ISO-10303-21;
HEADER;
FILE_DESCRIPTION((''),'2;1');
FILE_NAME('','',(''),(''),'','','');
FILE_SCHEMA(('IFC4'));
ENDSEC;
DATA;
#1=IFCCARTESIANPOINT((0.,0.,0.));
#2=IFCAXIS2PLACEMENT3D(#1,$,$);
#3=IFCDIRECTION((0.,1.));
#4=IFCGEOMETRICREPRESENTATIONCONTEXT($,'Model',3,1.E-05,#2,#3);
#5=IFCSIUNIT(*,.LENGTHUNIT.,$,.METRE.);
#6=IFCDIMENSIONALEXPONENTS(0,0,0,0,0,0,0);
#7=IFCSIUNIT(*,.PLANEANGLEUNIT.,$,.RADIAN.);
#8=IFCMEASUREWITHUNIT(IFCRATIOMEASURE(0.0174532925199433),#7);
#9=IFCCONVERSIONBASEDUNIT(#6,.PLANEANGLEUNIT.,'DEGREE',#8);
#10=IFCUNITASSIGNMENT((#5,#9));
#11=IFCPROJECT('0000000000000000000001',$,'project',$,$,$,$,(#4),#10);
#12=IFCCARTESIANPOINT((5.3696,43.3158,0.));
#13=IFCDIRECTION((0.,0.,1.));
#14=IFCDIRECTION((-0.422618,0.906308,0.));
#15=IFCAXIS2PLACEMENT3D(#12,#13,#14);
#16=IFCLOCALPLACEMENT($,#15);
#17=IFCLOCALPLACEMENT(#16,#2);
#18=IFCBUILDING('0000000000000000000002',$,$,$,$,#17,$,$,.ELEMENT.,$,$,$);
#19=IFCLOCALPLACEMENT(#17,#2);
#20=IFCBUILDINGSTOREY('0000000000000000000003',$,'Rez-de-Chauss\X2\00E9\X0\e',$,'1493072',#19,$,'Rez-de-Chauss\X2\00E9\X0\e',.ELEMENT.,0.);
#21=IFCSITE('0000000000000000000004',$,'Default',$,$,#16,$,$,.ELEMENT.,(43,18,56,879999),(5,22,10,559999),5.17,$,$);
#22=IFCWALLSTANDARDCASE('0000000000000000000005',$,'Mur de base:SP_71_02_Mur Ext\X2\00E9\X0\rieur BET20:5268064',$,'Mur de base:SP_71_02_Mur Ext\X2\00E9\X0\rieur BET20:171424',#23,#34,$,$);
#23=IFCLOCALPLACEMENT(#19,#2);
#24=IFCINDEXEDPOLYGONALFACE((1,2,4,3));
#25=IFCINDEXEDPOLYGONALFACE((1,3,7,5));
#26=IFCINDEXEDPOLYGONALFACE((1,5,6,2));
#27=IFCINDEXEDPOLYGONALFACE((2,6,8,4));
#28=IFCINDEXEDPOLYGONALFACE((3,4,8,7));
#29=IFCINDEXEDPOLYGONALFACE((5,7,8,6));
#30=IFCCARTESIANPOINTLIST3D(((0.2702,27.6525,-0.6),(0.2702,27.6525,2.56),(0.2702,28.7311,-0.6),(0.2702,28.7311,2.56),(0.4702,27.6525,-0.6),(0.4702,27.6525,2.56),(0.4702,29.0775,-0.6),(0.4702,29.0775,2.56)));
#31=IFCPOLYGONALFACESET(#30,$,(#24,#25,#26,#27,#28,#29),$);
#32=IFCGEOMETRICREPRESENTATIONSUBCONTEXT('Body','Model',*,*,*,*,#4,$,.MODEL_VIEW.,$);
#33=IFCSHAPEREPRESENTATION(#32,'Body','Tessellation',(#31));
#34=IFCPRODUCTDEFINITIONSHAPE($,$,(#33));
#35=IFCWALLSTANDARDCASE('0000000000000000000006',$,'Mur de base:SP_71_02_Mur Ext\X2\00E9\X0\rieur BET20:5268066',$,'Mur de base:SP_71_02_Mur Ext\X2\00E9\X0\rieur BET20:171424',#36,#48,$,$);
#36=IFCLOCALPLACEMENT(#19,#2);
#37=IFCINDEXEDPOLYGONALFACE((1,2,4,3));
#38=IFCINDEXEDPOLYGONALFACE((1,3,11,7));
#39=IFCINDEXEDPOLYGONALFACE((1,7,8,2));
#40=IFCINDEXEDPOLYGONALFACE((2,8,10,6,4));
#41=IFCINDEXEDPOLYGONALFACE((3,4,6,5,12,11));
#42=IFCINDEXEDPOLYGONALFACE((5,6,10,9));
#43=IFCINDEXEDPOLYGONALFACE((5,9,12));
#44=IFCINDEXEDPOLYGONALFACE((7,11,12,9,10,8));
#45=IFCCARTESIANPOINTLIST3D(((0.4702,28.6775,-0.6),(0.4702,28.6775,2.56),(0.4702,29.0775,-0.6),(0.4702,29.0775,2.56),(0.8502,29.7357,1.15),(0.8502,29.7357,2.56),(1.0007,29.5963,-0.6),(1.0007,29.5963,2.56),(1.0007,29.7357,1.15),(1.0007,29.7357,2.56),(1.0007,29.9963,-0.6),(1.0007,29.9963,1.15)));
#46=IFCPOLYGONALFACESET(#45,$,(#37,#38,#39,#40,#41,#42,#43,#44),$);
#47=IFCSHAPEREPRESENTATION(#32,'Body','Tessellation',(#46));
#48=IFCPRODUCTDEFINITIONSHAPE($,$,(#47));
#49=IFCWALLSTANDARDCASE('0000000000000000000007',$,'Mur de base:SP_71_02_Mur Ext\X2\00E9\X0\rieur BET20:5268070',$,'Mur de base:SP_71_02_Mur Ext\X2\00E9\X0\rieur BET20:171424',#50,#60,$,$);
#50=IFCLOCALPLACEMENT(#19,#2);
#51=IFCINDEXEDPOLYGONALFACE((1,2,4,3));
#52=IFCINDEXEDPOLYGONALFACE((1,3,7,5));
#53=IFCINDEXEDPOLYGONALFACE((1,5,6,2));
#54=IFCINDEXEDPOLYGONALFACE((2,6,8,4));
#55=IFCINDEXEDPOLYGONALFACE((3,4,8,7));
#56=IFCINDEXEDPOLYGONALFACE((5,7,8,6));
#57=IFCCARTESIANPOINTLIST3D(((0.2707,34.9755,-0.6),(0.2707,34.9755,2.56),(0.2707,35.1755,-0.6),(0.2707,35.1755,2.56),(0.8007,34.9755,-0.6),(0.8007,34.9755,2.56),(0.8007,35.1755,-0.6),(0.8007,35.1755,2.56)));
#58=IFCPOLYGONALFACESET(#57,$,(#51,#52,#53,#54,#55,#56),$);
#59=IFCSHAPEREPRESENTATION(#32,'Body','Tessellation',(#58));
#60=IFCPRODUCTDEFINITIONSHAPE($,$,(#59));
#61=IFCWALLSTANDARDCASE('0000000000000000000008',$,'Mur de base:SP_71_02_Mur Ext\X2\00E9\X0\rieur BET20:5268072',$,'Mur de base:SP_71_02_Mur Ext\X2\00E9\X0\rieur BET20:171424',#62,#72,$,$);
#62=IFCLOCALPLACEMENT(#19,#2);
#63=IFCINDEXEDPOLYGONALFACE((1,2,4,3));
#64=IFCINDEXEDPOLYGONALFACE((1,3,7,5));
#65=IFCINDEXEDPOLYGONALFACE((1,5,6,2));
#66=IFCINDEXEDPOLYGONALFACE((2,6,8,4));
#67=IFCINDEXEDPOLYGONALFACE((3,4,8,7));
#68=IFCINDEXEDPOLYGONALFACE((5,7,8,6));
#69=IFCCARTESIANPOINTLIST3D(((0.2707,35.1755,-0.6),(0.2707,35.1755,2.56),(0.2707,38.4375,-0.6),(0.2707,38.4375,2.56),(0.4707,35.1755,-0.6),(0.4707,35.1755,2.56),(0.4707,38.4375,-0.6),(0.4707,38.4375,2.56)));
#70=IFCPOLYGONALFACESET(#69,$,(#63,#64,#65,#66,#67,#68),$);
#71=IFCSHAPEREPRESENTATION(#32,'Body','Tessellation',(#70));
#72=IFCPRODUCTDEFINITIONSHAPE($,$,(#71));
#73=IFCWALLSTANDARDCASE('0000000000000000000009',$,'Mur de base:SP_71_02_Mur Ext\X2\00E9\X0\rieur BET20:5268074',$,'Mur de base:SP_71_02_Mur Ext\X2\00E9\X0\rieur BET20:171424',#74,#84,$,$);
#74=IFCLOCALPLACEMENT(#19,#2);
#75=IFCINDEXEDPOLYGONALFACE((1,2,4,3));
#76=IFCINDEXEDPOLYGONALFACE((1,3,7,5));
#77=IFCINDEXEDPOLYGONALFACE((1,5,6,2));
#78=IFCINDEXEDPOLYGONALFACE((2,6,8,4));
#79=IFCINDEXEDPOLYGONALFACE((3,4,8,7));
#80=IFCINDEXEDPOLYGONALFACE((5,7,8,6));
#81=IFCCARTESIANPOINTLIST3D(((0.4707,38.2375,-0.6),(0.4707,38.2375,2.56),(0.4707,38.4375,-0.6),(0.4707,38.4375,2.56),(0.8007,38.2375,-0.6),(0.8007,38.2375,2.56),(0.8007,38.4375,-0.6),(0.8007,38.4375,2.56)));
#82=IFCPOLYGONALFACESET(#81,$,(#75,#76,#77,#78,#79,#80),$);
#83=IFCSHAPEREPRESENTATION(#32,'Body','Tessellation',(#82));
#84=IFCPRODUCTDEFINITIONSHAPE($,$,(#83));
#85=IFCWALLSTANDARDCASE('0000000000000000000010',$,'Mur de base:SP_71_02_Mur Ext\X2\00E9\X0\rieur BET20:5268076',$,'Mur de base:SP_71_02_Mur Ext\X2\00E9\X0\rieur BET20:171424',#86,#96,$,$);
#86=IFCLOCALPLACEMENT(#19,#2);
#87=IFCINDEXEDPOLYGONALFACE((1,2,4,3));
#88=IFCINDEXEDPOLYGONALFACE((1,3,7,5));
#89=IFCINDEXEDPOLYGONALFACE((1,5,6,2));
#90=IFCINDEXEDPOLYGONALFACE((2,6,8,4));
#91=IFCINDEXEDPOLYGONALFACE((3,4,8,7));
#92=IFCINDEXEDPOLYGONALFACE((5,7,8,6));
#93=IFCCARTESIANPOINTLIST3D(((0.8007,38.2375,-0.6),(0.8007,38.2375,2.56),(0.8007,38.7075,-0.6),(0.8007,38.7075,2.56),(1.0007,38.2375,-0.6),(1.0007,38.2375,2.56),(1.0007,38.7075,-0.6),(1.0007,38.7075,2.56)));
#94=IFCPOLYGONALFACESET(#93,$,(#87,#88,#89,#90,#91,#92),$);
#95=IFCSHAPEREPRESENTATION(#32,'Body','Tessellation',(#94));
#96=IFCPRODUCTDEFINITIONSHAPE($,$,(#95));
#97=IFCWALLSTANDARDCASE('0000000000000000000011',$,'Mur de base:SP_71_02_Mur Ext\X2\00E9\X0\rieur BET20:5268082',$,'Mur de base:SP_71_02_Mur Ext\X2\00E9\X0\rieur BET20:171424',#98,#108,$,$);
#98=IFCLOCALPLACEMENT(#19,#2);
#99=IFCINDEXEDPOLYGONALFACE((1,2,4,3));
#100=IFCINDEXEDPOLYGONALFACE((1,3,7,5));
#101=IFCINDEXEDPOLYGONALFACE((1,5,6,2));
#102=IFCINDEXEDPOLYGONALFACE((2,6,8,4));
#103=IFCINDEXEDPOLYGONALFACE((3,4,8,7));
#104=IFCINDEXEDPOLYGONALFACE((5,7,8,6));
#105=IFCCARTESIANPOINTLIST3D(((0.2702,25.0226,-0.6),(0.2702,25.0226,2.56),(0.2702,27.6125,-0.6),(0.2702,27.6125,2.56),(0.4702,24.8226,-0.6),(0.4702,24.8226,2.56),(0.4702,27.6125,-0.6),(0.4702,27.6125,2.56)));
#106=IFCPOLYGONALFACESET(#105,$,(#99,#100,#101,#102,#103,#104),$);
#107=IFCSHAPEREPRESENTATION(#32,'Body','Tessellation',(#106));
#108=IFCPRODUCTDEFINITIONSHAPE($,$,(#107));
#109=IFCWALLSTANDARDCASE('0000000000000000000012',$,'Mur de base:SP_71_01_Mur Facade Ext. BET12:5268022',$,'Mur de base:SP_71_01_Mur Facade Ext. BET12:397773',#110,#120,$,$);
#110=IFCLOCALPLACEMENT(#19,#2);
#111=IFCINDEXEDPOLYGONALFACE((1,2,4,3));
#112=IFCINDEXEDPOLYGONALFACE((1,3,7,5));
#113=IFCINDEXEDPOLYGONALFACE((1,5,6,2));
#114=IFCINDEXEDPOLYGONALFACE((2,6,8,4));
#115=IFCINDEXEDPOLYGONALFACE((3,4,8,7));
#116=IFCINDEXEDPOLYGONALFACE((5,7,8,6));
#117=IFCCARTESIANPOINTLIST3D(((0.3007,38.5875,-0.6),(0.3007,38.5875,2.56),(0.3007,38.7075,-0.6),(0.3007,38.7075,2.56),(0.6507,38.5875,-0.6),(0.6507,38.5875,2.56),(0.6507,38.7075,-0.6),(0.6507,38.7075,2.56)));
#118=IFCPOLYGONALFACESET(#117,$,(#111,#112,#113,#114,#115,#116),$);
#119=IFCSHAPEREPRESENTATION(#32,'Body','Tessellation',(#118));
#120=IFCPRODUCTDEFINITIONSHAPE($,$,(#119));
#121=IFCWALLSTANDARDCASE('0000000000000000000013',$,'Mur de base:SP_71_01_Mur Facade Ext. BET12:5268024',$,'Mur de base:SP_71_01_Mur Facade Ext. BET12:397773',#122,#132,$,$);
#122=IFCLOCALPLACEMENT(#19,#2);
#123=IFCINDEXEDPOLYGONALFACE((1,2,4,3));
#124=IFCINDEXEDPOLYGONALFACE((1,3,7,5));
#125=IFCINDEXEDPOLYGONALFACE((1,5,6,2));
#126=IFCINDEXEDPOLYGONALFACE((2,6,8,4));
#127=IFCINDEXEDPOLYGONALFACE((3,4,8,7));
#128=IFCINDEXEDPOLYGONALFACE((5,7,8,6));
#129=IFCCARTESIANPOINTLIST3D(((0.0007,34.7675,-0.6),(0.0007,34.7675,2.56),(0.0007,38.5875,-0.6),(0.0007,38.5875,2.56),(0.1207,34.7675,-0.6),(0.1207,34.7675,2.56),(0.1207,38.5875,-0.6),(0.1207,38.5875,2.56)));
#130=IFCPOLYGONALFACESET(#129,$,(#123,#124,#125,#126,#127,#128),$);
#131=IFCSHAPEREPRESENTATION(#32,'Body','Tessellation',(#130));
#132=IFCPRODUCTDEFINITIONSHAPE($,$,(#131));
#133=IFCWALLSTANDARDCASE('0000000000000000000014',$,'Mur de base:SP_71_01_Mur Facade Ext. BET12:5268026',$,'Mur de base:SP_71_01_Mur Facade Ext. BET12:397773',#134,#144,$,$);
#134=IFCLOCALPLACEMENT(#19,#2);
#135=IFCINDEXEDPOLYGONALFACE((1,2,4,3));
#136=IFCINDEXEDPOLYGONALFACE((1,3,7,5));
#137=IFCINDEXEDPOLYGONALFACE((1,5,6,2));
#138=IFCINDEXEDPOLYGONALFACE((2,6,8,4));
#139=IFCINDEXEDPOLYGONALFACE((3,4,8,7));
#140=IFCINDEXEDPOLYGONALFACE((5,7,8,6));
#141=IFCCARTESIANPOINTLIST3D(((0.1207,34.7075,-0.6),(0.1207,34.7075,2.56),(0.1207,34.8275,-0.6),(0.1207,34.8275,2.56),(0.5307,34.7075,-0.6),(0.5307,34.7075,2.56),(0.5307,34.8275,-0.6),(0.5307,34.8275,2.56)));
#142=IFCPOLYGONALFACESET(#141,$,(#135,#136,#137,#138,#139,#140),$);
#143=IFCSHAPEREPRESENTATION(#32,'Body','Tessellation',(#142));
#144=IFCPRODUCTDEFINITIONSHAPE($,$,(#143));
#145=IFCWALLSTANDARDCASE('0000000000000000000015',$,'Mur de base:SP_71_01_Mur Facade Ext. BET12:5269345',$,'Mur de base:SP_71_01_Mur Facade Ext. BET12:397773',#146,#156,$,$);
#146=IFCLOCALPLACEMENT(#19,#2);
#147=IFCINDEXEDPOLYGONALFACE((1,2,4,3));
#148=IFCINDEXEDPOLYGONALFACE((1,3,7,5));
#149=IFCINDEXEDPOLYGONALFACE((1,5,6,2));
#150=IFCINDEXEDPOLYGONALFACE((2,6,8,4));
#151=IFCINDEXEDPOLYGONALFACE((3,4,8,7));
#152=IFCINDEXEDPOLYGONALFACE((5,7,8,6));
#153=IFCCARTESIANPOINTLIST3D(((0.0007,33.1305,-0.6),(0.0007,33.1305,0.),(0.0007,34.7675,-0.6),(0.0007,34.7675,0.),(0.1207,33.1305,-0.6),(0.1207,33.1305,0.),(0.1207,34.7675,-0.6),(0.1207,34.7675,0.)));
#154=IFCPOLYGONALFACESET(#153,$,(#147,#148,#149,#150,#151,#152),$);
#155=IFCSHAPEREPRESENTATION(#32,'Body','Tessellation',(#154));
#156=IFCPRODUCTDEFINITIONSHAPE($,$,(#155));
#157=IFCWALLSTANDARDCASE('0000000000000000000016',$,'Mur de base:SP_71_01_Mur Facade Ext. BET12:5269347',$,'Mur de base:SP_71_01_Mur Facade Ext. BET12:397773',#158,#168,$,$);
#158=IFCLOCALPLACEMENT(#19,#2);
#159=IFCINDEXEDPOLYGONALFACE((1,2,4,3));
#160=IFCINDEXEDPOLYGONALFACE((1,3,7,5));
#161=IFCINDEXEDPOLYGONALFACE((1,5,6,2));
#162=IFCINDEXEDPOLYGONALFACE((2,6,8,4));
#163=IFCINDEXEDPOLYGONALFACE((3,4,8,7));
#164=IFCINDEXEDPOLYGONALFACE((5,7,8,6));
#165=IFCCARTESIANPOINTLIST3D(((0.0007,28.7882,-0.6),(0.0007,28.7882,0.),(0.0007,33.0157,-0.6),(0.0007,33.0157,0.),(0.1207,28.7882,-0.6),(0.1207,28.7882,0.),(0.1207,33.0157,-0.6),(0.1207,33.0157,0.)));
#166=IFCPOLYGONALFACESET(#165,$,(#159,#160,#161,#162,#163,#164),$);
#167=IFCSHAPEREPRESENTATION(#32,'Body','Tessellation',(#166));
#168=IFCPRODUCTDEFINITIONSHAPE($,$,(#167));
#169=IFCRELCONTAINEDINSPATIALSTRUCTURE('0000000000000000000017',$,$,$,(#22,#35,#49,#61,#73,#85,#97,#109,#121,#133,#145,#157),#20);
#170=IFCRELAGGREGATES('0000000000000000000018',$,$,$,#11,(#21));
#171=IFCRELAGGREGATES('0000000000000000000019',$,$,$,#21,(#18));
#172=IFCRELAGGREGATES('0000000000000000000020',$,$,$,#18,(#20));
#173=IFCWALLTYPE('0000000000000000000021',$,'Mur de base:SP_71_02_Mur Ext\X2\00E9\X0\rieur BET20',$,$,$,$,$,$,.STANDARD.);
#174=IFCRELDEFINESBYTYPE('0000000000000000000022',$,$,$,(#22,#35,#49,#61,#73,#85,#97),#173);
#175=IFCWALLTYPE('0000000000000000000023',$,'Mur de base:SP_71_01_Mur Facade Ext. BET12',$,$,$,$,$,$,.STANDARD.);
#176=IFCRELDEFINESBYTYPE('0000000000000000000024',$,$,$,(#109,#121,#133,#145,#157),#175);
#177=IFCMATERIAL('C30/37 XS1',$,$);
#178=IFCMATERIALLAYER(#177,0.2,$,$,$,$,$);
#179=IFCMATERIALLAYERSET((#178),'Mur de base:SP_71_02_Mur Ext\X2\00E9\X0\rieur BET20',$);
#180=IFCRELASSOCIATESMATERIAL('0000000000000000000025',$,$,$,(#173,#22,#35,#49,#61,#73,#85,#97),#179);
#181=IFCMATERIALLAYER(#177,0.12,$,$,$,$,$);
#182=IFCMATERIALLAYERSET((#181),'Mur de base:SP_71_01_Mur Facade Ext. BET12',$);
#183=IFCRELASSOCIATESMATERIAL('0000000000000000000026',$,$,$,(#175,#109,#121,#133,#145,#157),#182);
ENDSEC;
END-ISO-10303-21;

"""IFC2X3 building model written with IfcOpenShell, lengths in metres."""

from ifc_helpers import new_model, entity, si_unit, converted_unit, direction, frame, frame_2d, origin, place, context, subcontext, project, spatial, polyline, rectangle, outline, extrude, clip, halfspace, bounded_halfspace, material, layer, layer_set, layer_usage, type_object, element, save


model = new_model("IFC2X3")

# Units and contexts
model_context = context("Model", 3, precision=1e-05, world=origin(), true_north=direction((0.0, 1.0)))
body_context = subcontext(model_context, "Body", "Model", "MODEL_VIEW")
ifc_project = project(units=[si_unit("LENGTHUNIT", "METRE"), converted_unit("PLANEANGLEUNIT", "DEGREE", entity("IfcRatioMeasure", 0.0174532925199433), si_unit("PLANEANGLEUNIT", "RADIAN"), dimensions=[0, 0, 0, 0, 0, 0, 0])], contexts=[model_context])

# Site, building, storey
site_placement = place(None, frame((5.3696, 43.3158, 0.0), z_axis=(0.0, 0.0, 1.0), x_axis=(-0.422618, 0.906308, 0.0)))
site = spatial("IfcSite", under=ifc_project, at=site_placement, Name="Default", CompositionType="ELEMENT", RefLatitude=(43, 18, 56, 879999), RefLongitude=(5, 22, 10, 559999), RefElevation=5.17)
building_placement = place(site_placement, origin())
building = spatial("IfcBuilding", under=site, at=building_placement, CompositionType="ELEMENT")
storey_placement = place(building_placement, origin())
storey = spatial("IfcBuildingStorey", under=building, at=storey_placement, Name="Rez-de-Chaussée", ObjectType="1493072", LongName="Rez-de-Chaussée", CompositionType="ELEMENT", Elevation=0.0)

# Wall
ifc_material_1 = material(Name="C30/37 XS1")
ifc_layer_1 = layer(ifc_material_1, 0.2)
ifc_layer_set_1 = layer_set([ifc_layer_1], Name="Mur de base:SP_71_02_Mur Extérieur BET20")
ifc_layer_usage_1 = layer_usage(ifc_layer_set_1, "AXIS2", "NEGATIVE", 0.1)
wall_type_1 = type_object("IfcWallType", Name="Mur de base:SP_71_02_Mur Extérieur BET20", PredefinedType="STANDARD", material=ifc_layer_set_1)
wall_1_placement = place(storey_placement, frame((0.3702, 29.0775, -0.6), z_axis=(0.0, 0.0, 1.0), x_axis=(0.0, -1.0, 0.0)))
element("IfcWallStandardCase", 1, at=wall_1_placement, inside=storey, type_object=wall_type_1, material=ifc_layer_usage_1, Name="Mur de base:SP_71_02_Mur Extérieur BET20:5268064", ObjectType="Mur de base:SP_71_02_Mur Extérieur BET20:171424", context=body_context, shape_type="Clipping", body=[
    clip(extrude(outline(polyline([(1.425, -0.1), (1.425, 0.1), (0.4, 0.1), (0.0, 0.1), (0.3464, -0.1), (1.425, -0.1)])), origin(), (0.0, 0.0, 1.0), 3.16), halfspace(frame((0.0, 0.0, -0.6)), True)),
])

# Wall, opening
ifc_layer_usage_2 = layer_usage(ifc_layer_set_1, "AXIS2", "NEGATIVE", 0.1)
wall_2_placement = place(storey_placement, frame((1.0873, 29.9463, -0.6), z_axis=(0.0, 0.0, 1.0), x_axis=(-0.5, -0.866025, 0.0)))
wall_2 = element("IfcWallStandardCase", 2, at=wall_2_placement, inside=storey, type_object=wall_type_1, material=ifc_layer_usage_2, Name="Mur de base:SP_71_02_Mur Extérieur BET20:5268066", ObjectType="Mur de base:SP_71_02_Mur Extérieur BET20:171424", context=body_context, shape_type="Clipping", body=[
    clip(extrude(outline(polyline([(1.0609, -0.1), (1.4073, 0.1), (0.3464, 0.1), (0.0, -0.1), (0.4, -0.1), (1.0609, -0.1)])), origin(), (0.0, 0.0, 1.0), 3.16), halfspace(frame((0.0, 0.0, -0.6)), True)),
])
opening_1_placement = place(wall_2_placement, origin())
element("IfcOpeningElement", 3, at=opening_1_placement, cuts=wall_2, ObjectType="Opening", context=body_context, shape_type="SweptSolid", body=[
    extrude(rectangle(XDim=2.56, YDim=3.22, at=frame_2d((0.0, 0.0), x_axis=(1.0, 0.0))), frame((-1.0686, -0.9479, 3.03), z_axis=(-0.5, 0.866025, 0.0), x_axis=(0.0, 0.0, -1.0)), (0.0, 0.0, 1.0), 0.2),
])

# Walls
ifc_layer_usage_3 = layer_usage(ifc_layer_set_1, "AXIS2", "NEGATIVE", 0.1)
wall_3_placement = place(storey_placement, frame((0.2707, 35.0755, -0.6)))
element("IfcWallStandardCase", 4, at=wall_3_placement, inside=storey, type_object=wall_type_1, material=ifc_layer_usage_3, Name="Mur de base:SP_71_02_Mur Extérieur BET20:5268070", ObjectType="Mur de base:SP_71_02_Mur Extérieur BET20:171424", context=body_context, shape_type="Clipping", body=[
    clip(extrude(rectangle(XDim=0.53, YDim=0.2, at=frame_2d((0.265, 0.0), x_axis=(-1.0, 0.0))), origin(), (0.0, 0.0, 1.0), 3.16), halfspace(frame((0.0, 0.0, -0.6)), True)),
])
ifc_layer_usage_4 = layer_usage(ifc_layer_set_1, "AXIS2", "NEGATIVE", 0.1)
wall_4_placement = place(storey_placement, frame((0.3707, 38.4375, -0.6), z_axis=(0.0, 0.0, 1.0), x_axis=(0.0, -1.0, 0.0)))
element("IfcWallStandardCase", 5, at=wall_4_placement, inside=storey, type_object=wall_type_1, material=ifc_layer_usage_4, Name="Mur de base:SP_71_02_Mur Extérieur BET20:5268072", ObjectType="Mur de base:SP_71_02_Mur Extérieur BET20:171424", context=body_context, shape_type="Clipping", body=[
    clip(extrude(rectangle(XDim=3.262, YDim=0.2, at=frame_2d((1.631, 0.0), x_axis=(-1.0, 0.0))), origin(), (0.0, 0.0, 1.0), 3.16), halfspace(frame((0.0, 0.0, -0.6)), True)),
])
ifc_layer_usage_5 = layer_usage(ifc_layer_set_1, "AXIS2", "NEGATIVE", 0.1)
wall_5_placement = place(storey_placement, frame((0.8007, 38.3375, -0.6), z_axis=(0.0, 0.0, 1.0), x_axis=(-1.0, 0.0, 0.0)))
element("IfcWallStandardCase", 6, at=wall_5_placement, inside=storey, type_object=wall_type_1, material=ifc_layer_usage_5, Name="Mur de base:SP_71_02_Mur Extérieur BET20:5268074", ObjectType="Mur de base:SP_71_02_Mur Extérieur BET20:171424", context=body_context, shape_type="Clipping", body=[
    clip(extrude(rectangle(XDim=0.33, YDim=0.2, at=frame_2d((0.165, 0.0), x_axis=(-1.0, 0.0))), origin(), (0.0, 0.0, 1.0), 3.16), halfspace(frame((0.0, 0.0, -0.6)), True)),
])
ifc_layer_usage_6 = layer_usage(ifc_layer_set_1, "AXIS2", "NEGATIVE", 0.1)
wall_6_placement = place(storey_placement, frame((0.9007, 38.7075, -0.6), z_axis=(0.0, 0.0, 1.0), x_axis=(0.0, -1.0, 0.0)))
element("IfcWallStandardCase", 7, at=wall_6_placement, inside=storey, type_object=wall_type_1, material=ifc_layer_usage_6, Name="Mur de base:SP_71_02_Mur Extérieur BET20:5268076", ObjectType="Mur de base:SP_71_02_Mur Extérieur BET20:171424", context=body_context, shape_type="Clipping", body=[
    clip(extrude(rectangle(XDim=0.47, YDim=0.2, at=frame_2d((0.235, 0.0), x_axis=(-1.0, 0.0))), origin(), (0.0, 0.0, 1.0), 3.16), halfspace(frame((0.0, 0.0, -0.6)), True)),
])
ifc_layer_usage_7 = layer_usage(ifc_layer_set_1, "AXIS2", "NEGATIVE", 0.1)
wall_7_placement = place(storey_placement, frame((0.3702, 27.6125, -0.6), z_axis=(0.0, 0.0, 1.0), x_axis=(0.0, -1.0, 0.0)))
element("IfcWallStandardCase", 8, at=wall_7_placement, inside=storey, type_object=wall_type_1, material=ifc_layer_usage_7, Name="Mur de base:SP_71_02_Mur Extérieur BET20:5268082", ObjectType="Mur de base:SP_71_02_Mur Extérieur BET20:171424", context=body_context, shape_type="Clipping", body=[
    clip(clip(extrude(outline(polyline([(2.5899, -0.1), (2.7899, 0.1), (0.0, 0.1), (0.0, -0.1), (2.5899, -0.1)])), origin(), (0.0, 0.0, 1.0), 3.16), bounded_halfspace(frame((0.0, 0.1, 5.63), z_axis=(0.0, 0.0, 1.0), x_axis=(0.0, 1.0, 0.0)), False, frame((0.0, 0.1, 5.63)), polyline([(0.0, 0.0), (0.0, -0.2), (0.7286, -0.2), (0.7286, 0.0), (0.0, 0.0)]))), halfspace(frame((0.0, 0.0, -0.6)), True)),
])
ifc_layer_2 = layer(ifc_material_1, 0.12)
ifc_layer_set_2 = layer_set([ifc_layer_2], Name="Mur de base:SP_71_01_Mur Facade Ext. BET12")
ifc_layer_usage_8 = layer_usage(ifc_layer_set_2, "AXIS2", "NEGATIVE", 0.06)
wall_type_2 = type_object("IfcWallType", Name="Mur de base:SP_71_01_Mur Facade Ext. BET12", PredefinedType="STANDARD", material=ifc_layer_set_2)
wall_8_placement = place(storey_placement, frame((0.6507, 38.6475, -0.6), z_axis=(0.0, 0.0, 1.0), x_axis=(-1.0, 0.0, 0.0)))
element("IfcWallStandardCase", 9, at=wall_8_placement, inside=storey, type_object=wall_type_2, material=ifc_layer_usage_8, Name="Mur de base:SP_71_01_Mur Facade Ext. BET12:5268022", ObjectType="Mur de base:SP_71_01_Mur Facade Ext. BET12:397773", context=body_context, shape_type="Clipping", body=[
    clip(extrude(rectangle(XDim=0.35, YDim=0.12, at=frame_2d((0.175, 0.0), x_axis=(-1.0, 0.0))), origin(), (0.0, 0.0, 1.0), 3.16), halfspace(frame((0.0, 0.0, -0.6)), True)),
])
ifc_layer_usage_9 = layer_usage(ifc_layer_set_2, "AXIS2", "NEGATIVE", 0.06)
wall_9_placement = place(storey_placement, frame((0.0607, 34.7075, -0.6), z_axis=(0.0, 0.0, 1.0), x_axis=(0.0, 1.0, 0.0)))
element("IfcWallStandardCase", 10, at=wall_9_placement, inside=storey, type_object=wall_type_2, material=ifc_layer_usage_9, Name="Mur de base:SP_71_01_Mur Facade Ext. BET12:5268024", ObjectType="Mur de base:SP_71_01_Mur Facade Ext. BET12:397773", context=body_context, shape_type="Clipping", body=[
    clip(extrude(rectangle(XDim=3.82, YDim=0.12, at=frame_2d((1.97, 0.0), x_axis=(-1.0, 0.0))), origin(), (0.0, 0.0, 1.0), 3.16), halfspace(frame((0.0, 0.0, -0.6)), True)),
])
ifc_layer_usage_10 = layer_usage(ifc_layer_set_2, "AXIS2", "NEGATIVE", 0.06)
wall_10_placement = place(storey_placement, frame((0.1207, 34.7675, -0.6)))
element("IfcWallStandardCase", 11, at=wall_10_placement, inside=storey, type_object=wall_type_2, material=ifc_layer_usage_10, Name="Mur de base:SP_71_01_Mur Facade Ext. BET12:5268026", ObjectType="Mur de base:SP_71_01_Mur Facade Ext. BET12:397773", context=body_context, shape_type="Clipping", body=[
    clip(extrude(rectangle(XDim=0.41, YDim=0.12, at=frame_2d((0.205, 0.0), x_axis=(-1.0, 0.0))), origin(), (0.0, 0.0, 1.0), 3.16), halfspace(frame((0.0, 0.0, -0.6)), True)),
])

# Walls
ifc_layer_usage_11 = layer_usage(ifc_layer_set_2, "AXIS2", "NEGATIVE", 0.06)
wall_11_placement = place(storey_placement, frame((0.0607, 34.7675, -0.6), z_axis=(0.0, 0.0, 1.0), x_axis=(0.0, -1.0, 0.0)))
element("IfcWallStandardCase", 12, at=wall_11_placement, inside=storey, type_object=wall_type_2, material=ifc_layer_usage_11, Name="Mur de base:SP_71_01_Mur Facade Ext. BET12:5269345", ObjectType="Mur de base:SP_71_01_Mur Facade Ext. BET12:397773", context=body_context, shape_type="SweptSolid", body=[
    extrude(rectangle(XDim=1.637, YDim=0.12, at=frame_2d((0.8185, 0.0), x_axis=(-1.0, 0.0))), origin(), (0.0, 0.0, 1.0), 0.6),
])
ifc_layer_usage_12 = layer_usage(ifc_layer_set_2, "AXIS2", "NEGATIVE", 0.06)
wall_12_placement = place(storey_placement, frame((0.0607, 33.0157, -0.6), z_axis=(0.0, 0.0, 1.0), x_axis=(0.0, -1.0, 0.0)))
element("IfcWallStandardCase", 13, at=wall_12_placement, inside=storey, type_object=wall_type_2, material=ifc_layer_usage_12, Name="Mur de base:SP_71_01_Mur Facade Ext. BET12:5269347", ObjectType="Mur de base:SP_71_01_Mur Facade Ext. BET12:397773", context=body_context, shape_type="SweptSolid", body=[
    extrude(rectangle(XDim=4.2276, YDim=0.12, at=frame_2d((2.1138, 0.0), x_axis=(-1.0, 0.0))), origin(), (0.0, 0.0, 1.0), 0.6),
])

save(model, "model.ifc")
